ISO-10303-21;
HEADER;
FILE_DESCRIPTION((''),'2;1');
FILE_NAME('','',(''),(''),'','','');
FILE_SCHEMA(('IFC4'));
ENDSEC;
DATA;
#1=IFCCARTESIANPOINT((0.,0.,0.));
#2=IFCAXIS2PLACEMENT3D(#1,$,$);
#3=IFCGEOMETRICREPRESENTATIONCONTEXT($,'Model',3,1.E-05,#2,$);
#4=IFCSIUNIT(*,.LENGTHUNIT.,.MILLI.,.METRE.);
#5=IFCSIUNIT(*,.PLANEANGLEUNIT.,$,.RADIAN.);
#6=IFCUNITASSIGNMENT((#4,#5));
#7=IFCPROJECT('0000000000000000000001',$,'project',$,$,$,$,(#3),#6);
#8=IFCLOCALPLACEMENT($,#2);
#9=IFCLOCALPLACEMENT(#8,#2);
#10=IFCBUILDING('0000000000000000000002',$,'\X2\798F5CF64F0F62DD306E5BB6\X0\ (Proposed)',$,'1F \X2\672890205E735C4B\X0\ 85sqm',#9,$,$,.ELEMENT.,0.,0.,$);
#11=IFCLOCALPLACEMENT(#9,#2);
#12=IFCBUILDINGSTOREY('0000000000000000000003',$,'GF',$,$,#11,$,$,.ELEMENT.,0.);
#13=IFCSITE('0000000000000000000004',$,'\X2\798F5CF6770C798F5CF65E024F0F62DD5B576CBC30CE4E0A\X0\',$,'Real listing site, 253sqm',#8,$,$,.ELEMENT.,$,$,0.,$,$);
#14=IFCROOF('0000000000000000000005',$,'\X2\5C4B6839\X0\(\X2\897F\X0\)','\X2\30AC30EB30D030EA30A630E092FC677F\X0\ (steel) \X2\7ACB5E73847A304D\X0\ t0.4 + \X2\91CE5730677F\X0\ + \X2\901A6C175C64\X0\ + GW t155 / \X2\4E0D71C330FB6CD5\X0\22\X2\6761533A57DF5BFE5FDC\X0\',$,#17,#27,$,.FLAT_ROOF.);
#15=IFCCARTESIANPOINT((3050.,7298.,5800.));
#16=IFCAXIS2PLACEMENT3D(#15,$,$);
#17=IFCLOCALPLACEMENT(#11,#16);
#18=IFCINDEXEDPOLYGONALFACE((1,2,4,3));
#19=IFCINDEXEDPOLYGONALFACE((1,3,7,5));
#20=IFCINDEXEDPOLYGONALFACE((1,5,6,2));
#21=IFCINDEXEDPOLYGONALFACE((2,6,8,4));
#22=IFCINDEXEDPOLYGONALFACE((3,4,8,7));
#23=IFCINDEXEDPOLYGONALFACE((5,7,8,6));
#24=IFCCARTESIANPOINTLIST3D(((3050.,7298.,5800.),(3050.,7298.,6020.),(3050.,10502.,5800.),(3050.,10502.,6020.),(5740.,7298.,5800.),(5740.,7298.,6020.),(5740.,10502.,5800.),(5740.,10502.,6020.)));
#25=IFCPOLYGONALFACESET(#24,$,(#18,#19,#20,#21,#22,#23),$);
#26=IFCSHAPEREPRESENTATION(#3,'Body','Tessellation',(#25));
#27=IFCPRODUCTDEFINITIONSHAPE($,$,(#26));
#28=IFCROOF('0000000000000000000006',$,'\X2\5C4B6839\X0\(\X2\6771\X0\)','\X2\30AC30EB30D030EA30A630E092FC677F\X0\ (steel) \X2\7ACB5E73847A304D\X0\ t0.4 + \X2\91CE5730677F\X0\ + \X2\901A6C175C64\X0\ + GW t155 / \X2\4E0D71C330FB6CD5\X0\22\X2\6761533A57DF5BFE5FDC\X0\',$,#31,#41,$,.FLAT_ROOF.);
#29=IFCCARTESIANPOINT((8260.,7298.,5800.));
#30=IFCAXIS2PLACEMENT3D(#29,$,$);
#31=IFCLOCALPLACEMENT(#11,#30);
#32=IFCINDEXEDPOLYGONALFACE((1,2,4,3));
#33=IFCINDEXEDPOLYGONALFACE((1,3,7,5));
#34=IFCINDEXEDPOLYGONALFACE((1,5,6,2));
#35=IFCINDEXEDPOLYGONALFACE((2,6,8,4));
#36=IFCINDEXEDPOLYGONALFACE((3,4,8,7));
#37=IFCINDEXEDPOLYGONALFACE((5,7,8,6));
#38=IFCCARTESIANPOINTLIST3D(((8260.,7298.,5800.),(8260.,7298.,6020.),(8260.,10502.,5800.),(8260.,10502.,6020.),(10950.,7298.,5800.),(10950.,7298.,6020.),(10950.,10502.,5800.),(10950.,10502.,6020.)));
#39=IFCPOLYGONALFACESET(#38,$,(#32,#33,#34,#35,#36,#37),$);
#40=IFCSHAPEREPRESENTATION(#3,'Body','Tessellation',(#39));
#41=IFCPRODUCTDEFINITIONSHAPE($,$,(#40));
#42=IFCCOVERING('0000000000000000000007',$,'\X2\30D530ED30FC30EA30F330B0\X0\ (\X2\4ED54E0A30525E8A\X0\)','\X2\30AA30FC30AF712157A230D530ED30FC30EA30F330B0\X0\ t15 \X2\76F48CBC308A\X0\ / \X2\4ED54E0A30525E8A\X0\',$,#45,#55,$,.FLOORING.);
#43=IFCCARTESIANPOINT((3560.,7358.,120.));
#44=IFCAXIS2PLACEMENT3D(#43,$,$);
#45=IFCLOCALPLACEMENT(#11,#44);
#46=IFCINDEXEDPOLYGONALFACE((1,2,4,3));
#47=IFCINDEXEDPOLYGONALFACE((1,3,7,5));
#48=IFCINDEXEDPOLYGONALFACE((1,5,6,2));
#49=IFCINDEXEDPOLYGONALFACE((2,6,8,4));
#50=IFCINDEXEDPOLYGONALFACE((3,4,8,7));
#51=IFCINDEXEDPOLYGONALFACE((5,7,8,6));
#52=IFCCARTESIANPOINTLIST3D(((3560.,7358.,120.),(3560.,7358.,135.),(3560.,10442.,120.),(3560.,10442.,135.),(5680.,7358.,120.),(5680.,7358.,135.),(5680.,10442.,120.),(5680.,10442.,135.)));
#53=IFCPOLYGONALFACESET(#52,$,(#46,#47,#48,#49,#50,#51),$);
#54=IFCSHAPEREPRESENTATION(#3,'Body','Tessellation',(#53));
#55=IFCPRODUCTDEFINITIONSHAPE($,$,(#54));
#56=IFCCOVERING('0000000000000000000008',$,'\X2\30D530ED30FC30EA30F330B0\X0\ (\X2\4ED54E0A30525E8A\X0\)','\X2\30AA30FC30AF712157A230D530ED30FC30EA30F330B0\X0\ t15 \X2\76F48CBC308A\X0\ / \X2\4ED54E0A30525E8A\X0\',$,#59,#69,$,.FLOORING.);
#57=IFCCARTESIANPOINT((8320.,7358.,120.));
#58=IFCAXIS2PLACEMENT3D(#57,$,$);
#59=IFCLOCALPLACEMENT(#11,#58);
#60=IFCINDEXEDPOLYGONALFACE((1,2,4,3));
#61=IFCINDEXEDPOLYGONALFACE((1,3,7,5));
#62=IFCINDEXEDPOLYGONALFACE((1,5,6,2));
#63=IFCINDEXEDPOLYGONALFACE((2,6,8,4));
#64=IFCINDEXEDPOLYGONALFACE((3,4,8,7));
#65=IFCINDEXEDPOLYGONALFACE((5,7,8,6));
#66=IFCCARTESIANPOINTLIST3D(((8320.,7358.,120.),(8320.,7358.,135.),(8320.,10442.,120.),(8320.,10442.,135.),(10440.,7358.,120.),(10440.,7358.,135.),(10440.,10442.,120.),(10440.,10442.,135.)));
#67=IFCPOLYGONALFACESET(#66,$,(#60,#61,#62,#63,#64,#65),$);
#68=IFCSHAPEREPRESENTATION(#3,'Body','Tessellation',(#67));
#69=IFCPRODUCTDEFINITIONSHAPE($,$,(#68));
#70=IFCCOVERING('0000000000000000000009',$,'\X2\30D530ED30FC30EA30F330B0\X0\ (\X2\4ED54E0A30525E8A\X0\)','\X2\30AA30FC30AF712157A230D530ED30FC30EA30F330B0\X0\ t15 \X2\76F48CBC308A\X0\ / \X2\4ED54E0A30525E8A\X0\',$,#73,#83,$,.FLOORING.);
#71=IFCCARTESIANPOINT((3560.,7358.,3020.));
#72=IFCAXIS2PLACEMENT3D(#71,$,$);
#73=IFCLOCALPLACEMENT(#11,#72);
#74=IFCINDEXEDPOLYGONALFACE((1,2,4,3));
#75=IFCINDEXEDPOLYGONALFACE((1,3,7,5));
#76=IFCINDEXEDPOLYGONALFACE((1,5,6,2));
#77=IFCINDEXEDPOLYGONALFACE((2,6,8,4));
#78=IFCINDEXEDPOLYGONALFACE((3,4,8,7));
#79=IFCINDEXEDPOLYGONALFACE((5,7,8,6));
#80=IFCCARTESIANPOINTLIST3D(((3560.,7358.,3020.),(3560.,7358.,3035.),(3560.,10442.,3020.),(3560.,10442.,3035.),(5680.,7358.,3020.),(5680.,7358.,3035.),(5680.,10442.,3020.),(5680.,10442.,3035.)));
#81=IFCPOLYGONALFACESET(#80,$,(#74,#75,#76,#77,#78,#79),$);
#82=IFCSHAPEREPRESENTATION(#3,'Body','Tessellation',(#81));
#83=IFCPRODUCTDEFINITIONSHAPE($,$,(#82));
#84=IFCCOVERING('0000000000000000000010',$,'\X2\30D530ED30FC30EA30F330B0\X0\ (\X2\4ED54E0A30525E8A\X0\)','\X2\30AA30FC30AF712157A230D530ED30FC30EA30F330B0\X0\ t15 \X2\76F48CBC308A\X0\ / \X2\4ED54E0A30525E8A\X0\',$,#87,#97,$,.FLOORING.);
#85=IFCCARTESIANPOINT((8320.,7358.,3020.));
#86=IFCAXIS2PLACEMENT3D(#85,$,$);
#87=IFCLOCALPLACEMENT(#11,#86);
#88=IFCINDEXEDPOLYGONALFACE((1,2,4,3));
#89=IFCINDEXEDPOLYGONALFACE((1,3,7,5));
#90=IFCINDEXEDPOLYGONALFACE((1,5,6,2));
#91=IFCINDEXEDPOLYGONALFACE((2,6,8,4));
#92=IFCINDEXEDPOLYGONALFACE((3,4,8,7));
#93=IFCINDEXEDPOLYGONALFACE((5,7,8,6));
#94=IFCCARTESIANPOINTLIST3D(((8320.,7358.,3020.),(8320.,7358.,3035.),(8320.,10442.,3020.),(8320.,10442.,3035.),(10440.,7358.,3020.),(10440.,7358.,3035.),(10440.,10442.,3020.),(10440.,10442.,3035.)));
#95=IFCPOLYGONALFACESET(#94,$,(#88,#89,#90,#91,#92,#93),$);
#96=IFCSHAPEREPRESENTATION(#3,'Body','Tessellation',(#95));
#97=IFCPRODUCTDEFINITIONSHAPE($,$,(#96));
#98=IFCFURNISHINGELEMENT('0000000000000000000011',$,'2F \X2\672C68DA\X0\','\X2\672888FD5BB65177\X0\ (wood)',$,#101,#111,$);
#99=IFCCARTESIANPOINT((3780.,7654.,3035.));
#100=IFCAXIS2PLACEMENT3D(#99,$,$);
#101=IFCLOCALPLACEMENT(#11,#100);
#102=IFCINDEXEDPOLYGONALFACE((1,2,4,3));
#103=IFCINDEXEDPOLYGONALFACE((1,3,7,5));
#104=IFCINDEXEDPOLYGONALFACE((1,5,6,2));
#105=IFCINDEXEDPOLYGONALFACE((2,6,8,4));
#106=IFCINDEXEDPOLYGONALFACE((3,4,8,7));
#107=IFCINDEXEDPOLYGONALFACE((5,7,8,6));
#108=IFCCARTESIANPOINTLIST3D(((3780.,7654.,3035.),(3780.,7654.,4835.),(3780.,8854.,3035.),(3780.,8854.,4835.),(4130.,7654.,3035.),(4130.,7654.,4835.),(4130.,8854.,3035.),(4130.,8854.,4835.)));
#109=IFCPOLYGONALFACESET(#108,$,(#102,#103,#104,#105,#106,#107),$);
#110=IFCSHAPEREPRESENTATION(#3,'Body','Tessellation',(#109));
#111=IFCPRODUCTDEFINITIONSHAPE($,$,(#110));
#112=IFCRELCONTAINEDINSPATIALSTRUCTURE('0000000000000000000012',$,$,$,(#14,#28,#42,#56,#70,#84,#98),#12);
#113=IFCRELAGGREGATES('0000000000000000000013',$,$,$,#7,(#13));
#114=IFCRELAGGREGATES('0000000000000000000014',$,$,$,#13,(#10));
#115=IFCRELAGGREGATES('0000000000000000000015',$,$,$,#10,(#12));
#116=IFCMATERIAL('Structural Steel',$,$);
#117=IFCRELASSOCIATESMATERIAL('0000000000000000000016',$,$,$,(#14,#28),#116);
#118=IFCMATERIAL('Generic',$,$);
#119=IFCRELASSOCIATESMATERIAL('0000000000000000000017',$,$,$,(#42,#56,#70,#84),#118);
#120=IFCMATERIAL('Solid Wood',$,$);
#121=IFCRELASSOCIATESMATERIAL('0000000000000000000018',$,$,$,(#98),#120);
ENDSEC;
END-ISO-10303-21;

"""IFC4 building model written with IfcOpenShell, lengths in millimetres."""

from ifc_helpers import new_model, si_unit, frame, frame_2d, origin, place, context, project, spatial, rectangle, extrude, material, element, save


model = new_model("IFC4")

# Units and contexts
model_context = context("Model", 3, precision=1e-05, world=origin())
ifc_project = project(units=[si_unit("LENGTHUNIT", "METRE", prefix="MILLI"), si_unit("PLANEANGLEUNIT", "RADIAN")], contexts=[model_context])

# Site, building, storey
site_placement = place(None, origin())
site = spatial("IfcSite", under=ifc_project, at=site_placement, Name="福島県福島市伏拝字沼ノ上", ObjectType="Real listing site, 253sqm", CompositionType="ELEMENT", RefElevation=0.0)
building_placement = place(site_placement, origin())
building = spatial("IfcBuilding", under=site, at=building_placement, Name="福島伏拝の家 (Proposed)", ObjectType="1F 木造平屋 85sqm", CompositionType="ELEMENT", ElevationOfRefHeight=0.0, ElevationOfTerrain=0.0)
storey_placement = place(building_placement, origin())
storey = spatial("IfcBuildingStorey", under=building, at=storey_placement, Name="GF", CompositionType="ELEMENT", Elevation=0.0)

# Shared definitions
ifc_material_1 = material(Name="Solid Wood")

# Roofs
ifc_material_2 = material(Name="Structural Steel")
roof_1_placement = place(storey_placement, frame((3050.0, 7298.0, 5800.0)))
element("IfcRoof", 1, at=roof_1_placement, inside=storey, material=ifc_material_2, Name="屋根(西)", Description="ガルバリウム鋼板 (steel) 立平葺き t0.4 + 野地板 + 通気層 + GW t155 / 不燃・法22条区域対応", PredefinedType="FLAT_ROOF", context=model_context, shape_type="SweptSolid", body=[
    extrude(rectangle(XDim=2690.0, YDim=3204.0, at=frame_2d((1345.0, 1602.0))), frame((3050.0, 7298.0, 5800.0)), (0.0, 0.0, 1.0), 220.0),
])
roof_2_placement = place(storey_placement, frame((8260.0, 7298.0, 5800.0)))
element("IfcRoof", 2, at=roof_2_placement, inside=storey, material=ifc_material_2, Name="屋根(東)", Description="ガルバリウム鋼板 (steel) 立平葺き t0.4 + 野地板 + 通気層 + GW t155 / 不燃・法22条区域対応", PredefinedType="FLAT_ROOF", context=model_context, shape_type="SweptSolid", body=[
    extrude(rectangle(XDim=2690.0, YDim=3204.0, at=frame_2d((1345.0, 1602.0))), frame((8260.0, 7298.0, 5800.0)), (0.0, 0.0, 1.0), 220.0),
])

# Coverings
ifc_material_3 = material(Name="Generic")
covering_1_placement = place(storey_placement, frame((3560.0, 7358.0, 120.0)))
element("IfcCovering", 3, at=covering_1_placement, inside=storey, material=ifc_material_3, Name="フローリング (仕上げ床)", Description="オーク無垢フローリング t15 直貼り / 仕上げ床", PredefinedType="FLOORING", context=model_context, shape_type="SweptSolid", body=[
    extrude(rectangle(XDim=2120.0, YDim=3084.0, at=frame_2d((1060.0, 1542.0))), frame((3560.0, 7358.0, 120.0)), (0.0, 0.0, 1.0), 15.0),
])
covering_2_placement = place(storey_placement, frame((8320.0, 7358.0, 120.0)))
element("IfcCovering", 4, at=covering_2_placement, inside=storey, material=ifc_material_3, Name="フローリング (仕上げ床)", Description="オーク無垢フローリング t15 直貼り / 仕上げ床", PredefinedType="FLOORING", context=model_context, shape_type="SweptSolid", body=[
    extrude(rectangle(XDim=2120.0, YDim=3084.0, at=frame_2d((1060.0, 1542.0))), frame((8320.0, 7358.0, 120.0)), (0.0, 0.0, 1.0), 15.0),
])
covering_3_placement = place(storey_placement, frame((3560.0, 7358.0, 3020.0)))
element("IfcCovering", 5, at=covering_3_placement, inside=storey, material=ifc_material_3, Name="フローリング (仕上げ床)", Description="オーク無垢フローリング t15 直貼り / 仕上げ床", PredefinedType="FLOORING", context=model_context, shape_type="SweptSolid", body=[
    extrude(rectangle(XDim=2120.0, YDim=3084.0, at=frame_2d((1060.0, 1542.0))), frame((3560.0, 7358.0, 3020.0)), (0.0, 0.0, 1.0), 15.0),
])
covering_4_placement = place(storey_placement, frame((8320.0, 7358.0, 3020.0)))
element("IfcCovering", 6, at=covering_4_placement, inside=storey, material=ifc_material_3, Name="フローリング (仕上げ床)", Description="オーク無垢フローリング t15 直貼り / 仕上げ床", PredefinedType="FLOORING", context=model_context, shape_type="SweptSolid", body=[
    extrude(rectangle(XDim=2120.0, YDim=3084.0, at=frame_2d((1060.0, 1542.0))), frame((8320.0, 7358.0, 3020.0)), (0.0, 0.0, 1.0), 15.0),
])

# Furnishing element
furnishing_placement = place(storey_placement, frame((3780.0, 7654.0, 3035.0)))
element("IfcFurnishingElement", 7, at=furnishing_placement, inside=storey, material=ifc_material_1, Name="2F 本棚", Description="木製家具 (wood)", context=model_context, shape_type="SweptSolid", body=[
    extrude(rectangle(XDim=350.0, YDim=1200.0, at=frame_2d((175.0, 600.0))), frame((3780.0, 7654.0, 3035.0)), (0.0, 0.0, 1.0), 1800.0),
])

save(model, "model.ifc")
